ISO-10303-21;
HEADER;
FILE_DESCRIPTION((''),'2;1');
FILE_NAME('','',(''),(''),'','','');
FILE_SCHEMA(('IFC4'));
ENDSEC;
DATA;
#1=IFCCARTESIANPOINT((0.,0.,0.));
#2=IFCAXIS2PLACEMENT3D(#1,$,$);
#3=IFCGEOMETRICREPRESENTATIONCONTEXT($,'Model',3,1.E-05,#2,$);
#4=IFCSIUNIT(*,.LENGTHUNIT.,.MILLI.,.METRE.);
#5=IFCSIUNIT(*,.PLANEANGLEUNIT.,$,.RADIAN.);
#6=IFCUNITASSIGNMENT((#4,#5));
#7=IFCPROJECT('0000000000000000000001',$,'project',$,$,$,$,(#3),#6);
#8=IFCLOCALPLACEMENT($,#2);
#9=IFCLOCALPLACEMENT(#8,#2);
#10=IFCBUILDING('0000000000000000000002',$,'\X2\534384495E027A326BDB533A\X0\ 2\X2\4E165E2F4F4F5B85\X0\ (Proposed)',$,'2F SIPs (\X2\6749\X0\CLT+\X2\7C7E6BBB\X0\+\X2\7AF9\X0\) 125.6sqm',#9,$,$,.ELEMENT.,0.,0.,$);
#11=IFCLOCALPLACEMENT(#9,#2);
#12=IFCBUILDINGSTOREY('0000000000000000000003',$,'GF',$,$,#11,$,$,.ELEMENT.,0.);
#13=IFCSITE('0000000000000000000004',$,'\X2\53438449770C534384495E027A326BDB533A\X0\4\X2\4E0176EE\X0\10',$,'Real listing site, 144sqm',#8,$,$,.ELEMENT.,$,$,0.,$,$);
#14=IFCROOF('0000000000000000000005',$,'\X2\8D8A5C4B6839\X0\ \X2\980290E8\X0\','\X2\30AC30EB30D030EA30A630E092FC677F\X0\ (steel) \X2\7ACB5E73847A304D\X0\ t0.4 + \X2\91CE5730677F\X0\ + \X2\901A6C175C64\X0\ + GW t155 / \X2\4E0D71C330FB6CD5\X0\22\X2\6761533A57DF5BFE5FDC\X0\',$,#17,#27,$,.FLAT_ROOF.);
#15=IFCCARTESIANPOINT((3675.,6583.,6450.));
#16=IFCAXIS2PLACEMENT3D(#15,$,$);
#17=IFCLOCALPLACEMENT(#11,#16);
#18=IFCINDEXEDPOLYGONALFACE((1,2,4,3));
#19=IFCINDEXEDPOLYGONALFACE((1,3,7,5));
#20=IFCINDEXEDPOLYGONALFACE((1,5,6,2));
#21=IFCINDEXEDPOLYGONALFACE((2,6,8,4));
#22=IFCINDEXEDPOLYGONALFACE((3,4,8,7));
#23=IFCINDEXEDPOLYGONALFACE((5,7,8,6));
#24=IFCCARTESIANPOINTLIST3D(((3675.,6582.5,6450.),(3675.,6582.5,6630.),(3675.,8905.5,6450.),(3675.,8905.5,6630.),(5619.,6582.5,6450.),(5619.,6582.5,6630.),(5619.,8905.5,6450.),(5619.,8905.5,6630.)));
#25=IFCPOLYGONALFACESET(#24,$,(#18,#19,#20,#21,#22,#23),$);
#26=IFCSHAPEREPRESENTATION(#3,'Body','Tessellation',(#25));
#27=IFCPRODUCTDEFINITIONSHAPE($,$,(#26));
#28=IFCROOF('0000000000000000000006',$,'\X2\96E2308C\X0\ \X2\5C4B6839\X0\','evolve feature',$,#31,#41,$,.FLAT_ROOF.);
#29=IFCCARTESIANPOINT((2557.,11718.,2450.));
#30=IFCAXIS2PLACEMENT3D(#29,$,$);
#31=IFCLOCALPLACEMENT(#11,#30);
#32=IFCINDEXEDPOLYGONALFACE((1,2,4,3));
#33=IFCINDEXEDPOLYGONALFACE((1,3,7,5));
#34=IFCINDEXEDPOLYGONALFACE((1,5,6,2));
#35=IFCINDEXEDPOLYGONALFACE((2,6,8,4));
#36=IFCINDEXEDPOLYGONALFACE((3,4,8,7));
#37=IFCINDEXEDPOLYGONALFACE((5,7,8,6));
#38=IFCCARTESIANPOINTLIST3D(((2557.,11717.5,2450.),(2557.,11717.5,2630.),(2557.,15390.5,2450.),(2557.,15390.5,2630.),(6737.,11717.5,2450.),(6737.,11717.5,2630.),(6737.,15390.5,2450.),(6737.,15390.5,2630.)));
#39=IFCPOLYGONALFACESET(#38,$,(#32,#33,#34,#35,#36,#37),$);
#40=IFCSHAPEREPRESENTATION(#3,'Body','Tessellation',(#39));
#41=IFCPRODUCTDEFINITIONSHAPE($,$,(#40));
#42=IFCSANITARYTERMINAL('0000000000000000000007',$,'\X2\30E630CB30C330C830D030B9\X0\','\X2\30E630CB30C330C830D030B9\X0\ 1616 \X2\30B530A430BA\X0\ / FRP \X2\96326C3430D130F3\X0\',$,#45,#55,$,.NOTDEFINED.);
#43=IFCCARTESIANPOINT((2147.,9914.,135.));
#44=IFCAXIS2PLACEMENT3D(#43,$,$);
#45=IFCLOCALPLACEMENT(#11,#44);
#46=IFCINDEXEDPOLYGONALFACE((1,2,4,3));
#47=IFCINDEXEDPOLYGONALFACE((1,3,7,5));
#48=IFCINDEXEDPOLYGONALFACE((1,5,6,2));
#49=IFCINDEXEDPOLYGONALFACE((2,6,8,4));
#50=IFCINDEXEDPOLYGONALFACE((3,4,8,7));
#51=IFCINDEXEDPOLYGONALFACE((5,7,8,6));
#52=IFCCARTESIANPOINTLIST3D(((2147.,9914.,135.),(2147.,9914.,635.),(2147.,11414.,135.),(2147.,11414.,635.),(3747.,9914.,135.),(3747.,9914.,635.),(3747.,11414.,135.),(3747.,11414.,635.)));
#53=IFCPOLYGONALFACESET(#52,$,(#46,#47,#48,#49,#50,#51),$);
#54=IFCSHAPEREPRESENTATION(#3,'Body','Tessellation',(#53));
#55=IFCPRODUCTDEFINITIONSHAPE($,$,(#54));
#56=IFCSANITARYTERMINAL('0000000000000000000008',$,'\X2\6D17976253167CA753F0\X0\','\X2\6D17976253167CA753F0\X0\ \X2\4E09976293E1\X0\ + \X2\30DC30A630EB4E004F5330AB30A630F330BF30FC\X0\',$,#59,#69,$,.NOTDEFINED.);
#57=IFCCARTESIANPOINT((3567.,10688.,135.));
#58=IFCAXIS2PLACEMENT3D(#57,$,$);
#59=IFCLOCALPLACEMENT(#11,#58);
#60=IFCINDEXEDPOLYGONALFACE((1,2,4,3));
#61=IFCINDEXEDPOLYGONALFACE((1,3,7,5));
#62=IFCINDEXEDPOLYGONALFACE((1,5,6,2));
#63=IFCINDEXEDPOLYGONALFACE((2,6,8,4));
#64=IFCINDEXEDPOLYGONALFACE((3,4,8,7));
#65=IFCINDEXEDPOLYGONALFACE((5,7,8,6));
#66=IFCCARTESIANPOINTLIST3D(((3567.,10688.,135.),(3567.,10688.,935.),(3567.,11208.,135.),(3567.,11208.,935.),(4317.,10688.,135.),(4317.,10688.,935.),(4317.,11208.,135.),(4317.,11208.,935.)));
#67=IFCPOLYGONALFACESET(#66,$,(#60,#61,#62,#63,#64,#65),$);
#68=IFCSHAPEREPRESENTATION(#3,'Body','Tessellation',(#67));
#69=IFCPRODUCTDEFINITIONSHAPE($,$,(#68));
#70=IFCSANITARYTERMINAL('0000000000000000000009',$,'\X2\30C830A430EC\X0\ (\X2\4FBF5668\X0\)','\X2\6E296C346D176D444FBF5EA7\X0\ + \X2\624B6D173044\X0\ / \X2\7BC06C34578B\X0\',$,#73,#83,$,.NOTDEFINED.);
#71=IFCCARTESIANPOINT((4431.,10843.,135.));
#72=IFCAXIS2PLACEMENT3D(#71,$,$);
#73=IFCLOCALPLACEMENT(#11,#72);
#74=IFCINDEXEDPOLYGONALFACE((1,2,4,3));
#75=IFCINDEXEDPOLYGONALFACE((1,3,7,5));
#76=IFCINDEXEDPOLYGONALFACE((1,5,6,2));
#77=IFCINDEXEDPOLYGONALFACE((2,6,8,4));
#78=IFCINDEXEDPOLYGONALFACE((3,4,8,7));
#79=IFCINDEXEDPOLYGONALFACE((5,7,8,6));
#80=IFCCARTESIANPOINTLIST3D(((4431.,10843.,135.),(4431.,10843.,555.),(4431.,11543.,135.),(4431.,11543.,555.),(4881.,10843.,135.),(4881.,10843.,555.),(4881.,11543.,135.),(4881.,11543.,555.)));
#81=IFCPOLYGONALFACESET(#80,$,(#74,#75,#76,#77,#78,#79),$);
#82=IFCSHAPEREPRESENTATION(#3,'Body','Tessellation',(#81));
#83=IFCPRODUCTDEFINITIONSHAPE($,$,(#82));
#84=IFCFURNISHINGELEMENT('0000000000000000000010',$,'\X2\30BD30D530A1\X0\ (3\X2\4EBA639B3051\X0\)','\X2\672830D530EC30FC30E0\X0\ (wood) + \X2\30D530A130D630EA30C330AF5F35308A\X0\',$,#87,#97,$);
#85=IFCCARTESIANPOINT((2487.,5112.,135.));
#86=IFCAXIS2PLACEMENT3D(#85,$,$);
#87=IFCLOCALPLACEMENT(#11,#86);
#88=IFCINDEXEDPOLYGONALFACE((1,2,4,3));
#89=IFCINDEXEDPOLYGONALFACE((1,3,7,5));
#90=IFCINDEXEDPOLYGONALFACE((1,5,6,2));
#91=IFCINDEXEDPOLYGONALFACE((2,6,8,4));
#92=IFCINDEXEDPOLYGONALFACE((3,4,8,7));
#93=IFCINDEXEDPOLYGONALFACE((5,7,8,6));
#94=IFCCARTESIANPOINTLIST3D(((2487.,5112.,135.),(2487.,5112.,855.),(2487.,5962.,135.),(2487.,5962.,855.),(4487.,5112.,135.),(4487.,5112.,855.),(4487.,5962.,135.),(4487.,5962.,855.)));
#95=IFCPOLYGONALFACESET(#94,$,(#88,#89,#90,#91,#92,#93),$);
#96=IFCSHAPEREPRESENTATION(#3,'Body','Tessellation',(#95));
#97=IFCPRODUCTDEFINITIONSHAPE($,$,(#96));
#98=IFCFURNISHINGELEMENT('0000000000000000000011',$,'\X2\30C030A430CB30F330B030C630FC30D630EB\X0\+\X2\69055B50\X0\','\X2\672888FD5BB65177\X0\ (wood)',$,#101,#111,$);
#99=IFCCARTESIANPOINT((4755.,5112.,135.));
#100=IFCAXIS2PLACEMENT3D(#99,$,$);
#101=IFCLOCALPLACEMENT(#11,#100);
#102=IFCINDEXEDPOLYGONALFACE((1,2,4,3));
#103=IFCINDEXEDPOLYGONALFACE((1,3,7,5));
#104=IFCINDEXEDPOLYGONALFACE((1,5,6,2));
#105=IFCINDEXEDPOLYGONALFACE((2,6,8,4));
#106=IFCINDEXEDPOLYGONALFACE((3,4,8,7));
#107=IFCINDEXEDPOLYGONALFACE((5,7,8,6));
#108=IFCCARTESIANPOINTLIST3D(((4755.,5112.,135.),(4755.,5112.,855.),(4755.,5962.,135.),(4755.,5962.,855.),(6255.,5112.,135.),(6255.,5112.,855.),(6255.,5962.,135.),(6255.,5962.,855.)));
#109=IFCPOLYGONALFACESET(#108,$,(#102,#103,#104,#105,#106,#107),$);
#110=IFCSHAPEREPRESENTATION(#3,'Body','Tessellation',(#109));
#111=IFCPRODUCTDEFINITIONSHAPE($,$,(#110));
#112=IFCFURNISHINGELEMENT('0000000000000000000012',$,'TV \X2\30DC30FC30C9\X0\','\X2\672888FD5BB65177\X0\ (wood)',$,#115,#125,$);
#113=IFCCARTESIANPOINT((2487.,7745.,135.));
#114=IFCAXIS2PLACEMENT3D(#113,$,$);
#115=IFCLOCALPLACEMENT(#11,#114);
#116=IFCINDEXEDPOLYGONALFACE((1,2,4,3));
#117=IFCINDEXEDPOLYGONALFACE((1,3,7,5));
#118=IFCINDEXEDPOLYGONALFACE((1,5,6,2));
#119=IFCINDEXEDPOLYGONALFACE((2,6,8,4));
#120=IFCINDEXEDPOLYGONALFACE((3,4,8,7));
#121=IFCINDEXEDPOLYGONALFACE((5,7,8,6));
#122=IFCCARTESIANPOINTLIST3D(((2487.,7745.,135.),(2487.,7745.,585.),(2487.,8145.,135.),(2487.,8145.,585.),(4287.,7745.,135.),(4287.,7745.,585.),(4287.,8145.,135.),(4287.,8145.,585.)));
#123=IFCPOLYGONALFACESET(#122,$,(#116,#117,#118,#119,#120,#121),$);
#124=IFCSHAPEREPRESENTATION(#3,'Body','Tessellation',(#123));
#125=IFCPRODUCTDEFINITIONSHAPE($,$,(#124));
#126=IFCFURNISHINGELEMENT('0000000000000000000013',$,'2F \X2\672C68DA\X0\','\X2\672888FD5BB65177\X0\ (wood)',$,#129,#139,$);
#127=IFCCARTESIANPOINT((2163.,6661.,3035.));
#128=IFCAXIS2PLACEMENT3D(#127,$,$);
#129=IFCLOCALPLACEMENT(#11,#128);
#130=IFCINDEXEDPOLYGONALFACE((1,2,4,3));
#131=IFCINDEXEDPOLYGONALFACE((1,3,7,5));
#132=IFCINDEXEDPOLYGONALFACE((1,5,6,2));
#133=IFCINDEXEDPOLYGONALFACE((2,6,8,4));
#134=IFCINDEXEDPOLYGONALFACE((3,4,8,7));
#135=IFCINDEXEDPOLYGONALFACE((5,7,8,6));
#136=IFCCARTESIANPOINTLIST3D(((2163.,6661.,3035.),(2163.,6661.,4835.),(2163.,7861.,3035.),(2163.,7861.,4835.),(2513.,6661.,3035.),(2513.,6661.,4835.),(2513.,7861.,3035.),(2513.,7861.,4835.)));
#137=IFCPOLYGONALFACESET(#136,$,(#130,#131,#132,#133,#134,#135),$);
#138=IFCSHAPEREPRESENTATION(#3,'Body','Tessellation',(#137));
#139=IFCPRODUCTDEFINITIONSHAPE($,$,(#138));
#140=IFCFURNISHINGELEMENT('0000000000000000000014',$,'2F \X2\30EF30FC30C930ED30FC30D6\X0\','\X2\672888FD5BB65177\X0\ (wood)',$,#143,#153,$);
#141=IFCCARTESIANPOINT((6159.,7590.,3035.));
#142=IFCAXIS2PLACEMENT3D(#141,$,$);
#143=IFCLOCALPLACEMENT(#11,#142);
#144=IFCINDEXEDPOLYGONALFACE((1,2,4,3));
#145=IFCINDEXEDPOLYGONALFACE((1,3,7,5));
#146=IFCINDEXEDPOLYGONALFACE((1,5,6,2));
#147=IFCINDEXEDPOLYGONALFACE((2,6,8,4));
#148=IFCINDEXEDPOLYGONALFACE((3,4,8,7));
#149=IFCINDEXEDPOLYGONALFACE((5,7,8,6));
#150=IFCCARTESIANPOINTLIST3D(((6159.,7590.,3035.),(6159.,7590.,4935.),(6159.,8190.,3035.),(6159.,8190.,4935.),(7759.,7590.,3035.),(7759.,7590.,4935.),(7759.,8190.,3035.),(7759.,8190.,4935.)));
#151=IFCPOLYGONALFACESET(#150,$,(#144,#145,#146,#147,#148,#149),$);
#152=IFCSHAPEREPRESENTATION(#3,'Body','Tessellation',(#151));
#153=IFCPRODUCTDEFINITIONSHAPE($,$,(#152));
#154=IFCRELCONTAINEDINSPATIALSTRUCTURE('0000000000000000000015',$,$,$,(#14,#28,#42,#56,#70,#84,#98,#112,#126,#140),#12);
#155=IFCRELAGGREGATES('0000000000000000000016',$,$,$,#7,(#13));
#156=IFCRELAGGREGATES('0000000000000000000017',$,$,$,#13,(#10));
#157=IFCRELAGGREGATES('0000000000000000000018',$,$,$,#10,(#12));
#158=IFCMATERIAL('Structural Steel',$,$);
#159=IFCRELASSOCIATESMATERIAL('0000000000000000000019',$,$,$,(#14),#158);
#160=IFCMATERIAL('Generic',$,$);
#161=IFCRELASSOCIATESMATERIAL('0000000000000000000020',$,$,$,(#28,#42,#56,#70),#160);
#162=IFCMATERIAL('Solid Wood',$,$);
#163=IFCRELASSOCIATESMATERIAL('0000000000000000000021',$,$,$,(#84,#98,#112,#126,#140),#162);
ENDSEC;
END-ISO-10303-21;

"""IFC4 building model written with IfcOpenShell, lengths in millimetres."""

from ifc_helpers import new_model, si_unit, frame, frame_2d, origin, place, context, project, spatial, rectangle, extrude, material, element, save


model = new_model("IFC4")

# Units and contexts
model_context = context("Model", 3, precision=1e-05, world=origin())
ifc_project = project(units=[si_unit("LENGTHUNIT", "METRE", prefix="MILLI"), si_unit("PLANEANGLEUNIT", "RADIAN")], contexts=[model_context])

# Site, building, storey
site_placement = place(None, origin())
site = spatial("IfcSite", under=ifc_project, at=site_placement, Name="千葉県千葉市稲毛区4丁目10", ObjectType="Real listing site, 144sqm", CompositionType="ELEMENT", RefElevation=0.0)
building_placement = place(site_placement, origin())
building = spatial("IfcBuilding", under=site, at=building_placement, Name="千葉市稲毛区 2世帯住宅 (Proposed)", ObjectType="2F SIPs (杉CLT+籾殻+竹) 125.6sqm", CompositionType="ELEMENT", ElevationOfRefHeight=0.0, ElevationOfTerrain=0.0)
storey_placement = place(building_placement, origin())
storey = spatial("IfcBuildingStorey", under=building, at=storey_placement, Name="GF", CompositionType="ELEMENT", Elevation=0.0)

# Shared definitions
ifc_material_1 = material(Name="Generic")

# Shared definitions
ifc_material_2 = material(Name="Solid Wood")

# Roofs
ifc_material_3 = material(Name="Structural Steel")
roof_1_placement = place(storey_placement, frame((3675.0, 6583.0, 6450.0)))
element("IfcRoof", 1, at=roof_1_placement, inside=storey, material=ifc_material_3, Name="越屋根 頂部", Description="ガルバリウム鋼板 (steel) 立平葺き t0.4 + 野地板 + 通気層 + GW t155 / 不燃・法22条区域対応", PredefinedType="FLAT_ROOF", context=model_context, shape_type="SweptSolid", body=[
    extrude(rectangle(XDim=1944.0, YDim=2323.0, at=frame_2d((972.0, 1161.0))), frame((3675.0, 6583.0, 6450.0)), (0.0, 0.0, 1.0), 180.0),
])
roof_2_placement = place(storey_placement, frame((2557.0, 11718.0, 2450.0)))
element("IfcRoof", 2, at=roof_2_placement, inside=storey, material=ifc_material_1, Name="離れ 屋根", Description="evolve feature", PredefinedType="FLAT_ROOF", context=model_context, shape_type="SweptSolid", body=[
    extrude(rectangle(XDim=4180.0, YDim=3673.0, at=frame_2d((2090.0, 1836.0))), frame((2557.0, 11718.0, 2450.0)), (0.0, 0.0, 1.0), 180.0),
])

# Sanitary terminals
sanitary_terminal_1_placement = place(storey_placement, frame((2147.0, 9914.0, 135.0)))
element("IfcSanitaryTerminal", 3, at=sanitary_terminal_1_placement, inside=storey, material=ifc_material_1, Name="ユニットバス", Description="ユニットバス 1616 サイズ / FRP 防水パン", PredefinedType="NOTDEFINED", context=model_context, shape_type="SweptSolid", body=[
    extrude(rectangle(XDim=1600.0, YDim=1500.0, at=frame_2d((800.0, 750.0))), frame((2147.0, 9914.0, 135.0)), (0.0, 0.0, 1.0), 500.0),
])
sanitary_terminal_2_placement = place(storey_placement, frame((3567.0, 10688.0, 135.0)))
element("IfcSanitaryTerminal", 4, at=sanitary_terminal_2_placement, inside=storey, material=ifc_material_1, Name="洗面化粧台", Description="洗面化粧台 三面鏡 + ボウル一体カウンター", PredefinedType="NOTDEFINED", context=model_context, shape_type="SweptSolid", body=[
    extrude(rectangle(XDim=750.0, YDim=520.0, at=frame_2d((375.0, 260.0))), frame((3567.0, 10688.0, 135.0)), (0.0, 0.0, 1.0), 800.0),
])
sanitary_terminal_3_placement = place(storey_placement, frame((4431.0, 10843.0, 135.0)))
element("IfcSanitaryTerminal", 5, at=sanitary_terminal_3_placement, inside=storey, material=ifc_material_1, Name="トイレ (便器)", Description="温水洗浄便座 + 手洗い / 節水型", PredefinedType="NOTDEFINED", context=model_context, shape_type="SweptSolid", body=[
    extrude(rectangle(XDim=450.0, YDim=700.0, at=frame_2d((225.0, 350.0))), frame((4431.0, 10843.0, 135.0)), (0.0, 0.0, 1.0), 420.0),
])

# Furnishing elements
furnishing_1_placement = place(storey_placement, frame((2487.0, 5112.0, 135.0)))
element("IfcFurnishingElement", 6, at=furnishing_1_placement, inside=storey, material=ifc_material_2, Name="ソファ (3人掛け)", Description="木フレーム (wood) + ファブリック張り", context=model_context, shape_type="SweptSolid", body=[
    extrude(rectangle(XDim=2000.0, YDim=850.0, at=frame_2d((1000.0, 425.0))), frame((2487.0, 5112.0, 135.0)), (0.0, 0.0, 1.0), 720.0),
])
furnishing_2_placement = place(storey_placement, frame((4755.0, 5112.0, 135.0)))
element("IfcFurnishingElement", 7, at=furnishing_2_placement, inside=storey, material=ifc_material_2, Name="ダイニングテーブル+椅子", Description="木製家具 (wood)", context=model_context, shape_type="SweptSolid", body=[
    extrude(rectangle(XDim=1500.0, YDim=850.0, at=frame_2d((750.0, 425.0))), frame((4755.0, 5112.0, 135.0)), (0.0, 0.0, 1.0), 720.0),
])
furnishing_3_placement = place(storey_placement, frame((2487.0, 7745.0, 135.0)))
element("IfcFurnishingElement", 8, at=furnishing_3_placement, inside=storey, material=ifc_material_2, Name="TV ボード", Description="木製家具 (wood)", context=model_context, shape_type="SweptSolid", body=[
    extrude(rectangle(XDim=1800.0, YDim=400.0, at=frame_2d((900.0, 200.0))), frame((2487.0, 7745.0, 135.0)), (0.0, 0.0, 1.0), 450.0),
])
furnishing_4_placement = place(storey_placement, frame((2163.0, 6661.0, 3035.0)))
element("IfcFurnishingElement", 9, at=furnishing_4_placement, inside=storey, material=ifc_material_2, Name="2F 本棚", Description="木製家具 (wood)", context=model_context, shape_type="SweptSolid", body=[
    extrude(rectangle(XDim=350.0, YDim=1200.0, at=frame_2d((175.0, 600.0))), frame((2163.0, 6661.0, 3035.0)), (0.0, 0.0, 1.0), 1800.0),
])
furnishing_5_placement = place(storey_placement, frame((6159.0, 7590.0, 3035.0)))
element("IfcFurnishingElement", 10, at=furnishing_5_placement, inside=storey, material=ifc_material_2, Name="2F ワードローブ", Description="木製家具 (wood)", context=model_context, shape_type="SweptSolid", body=[
    extrude(rectangle(XDim=1600.0, YDim=600.0, at=frame_2d((800.0, 300.0))), frame((6159.0, 7590.0, 3035.0)), (0.0, 0.0, 1.0), 1900.0),
])

save(model, "model.ifc")
